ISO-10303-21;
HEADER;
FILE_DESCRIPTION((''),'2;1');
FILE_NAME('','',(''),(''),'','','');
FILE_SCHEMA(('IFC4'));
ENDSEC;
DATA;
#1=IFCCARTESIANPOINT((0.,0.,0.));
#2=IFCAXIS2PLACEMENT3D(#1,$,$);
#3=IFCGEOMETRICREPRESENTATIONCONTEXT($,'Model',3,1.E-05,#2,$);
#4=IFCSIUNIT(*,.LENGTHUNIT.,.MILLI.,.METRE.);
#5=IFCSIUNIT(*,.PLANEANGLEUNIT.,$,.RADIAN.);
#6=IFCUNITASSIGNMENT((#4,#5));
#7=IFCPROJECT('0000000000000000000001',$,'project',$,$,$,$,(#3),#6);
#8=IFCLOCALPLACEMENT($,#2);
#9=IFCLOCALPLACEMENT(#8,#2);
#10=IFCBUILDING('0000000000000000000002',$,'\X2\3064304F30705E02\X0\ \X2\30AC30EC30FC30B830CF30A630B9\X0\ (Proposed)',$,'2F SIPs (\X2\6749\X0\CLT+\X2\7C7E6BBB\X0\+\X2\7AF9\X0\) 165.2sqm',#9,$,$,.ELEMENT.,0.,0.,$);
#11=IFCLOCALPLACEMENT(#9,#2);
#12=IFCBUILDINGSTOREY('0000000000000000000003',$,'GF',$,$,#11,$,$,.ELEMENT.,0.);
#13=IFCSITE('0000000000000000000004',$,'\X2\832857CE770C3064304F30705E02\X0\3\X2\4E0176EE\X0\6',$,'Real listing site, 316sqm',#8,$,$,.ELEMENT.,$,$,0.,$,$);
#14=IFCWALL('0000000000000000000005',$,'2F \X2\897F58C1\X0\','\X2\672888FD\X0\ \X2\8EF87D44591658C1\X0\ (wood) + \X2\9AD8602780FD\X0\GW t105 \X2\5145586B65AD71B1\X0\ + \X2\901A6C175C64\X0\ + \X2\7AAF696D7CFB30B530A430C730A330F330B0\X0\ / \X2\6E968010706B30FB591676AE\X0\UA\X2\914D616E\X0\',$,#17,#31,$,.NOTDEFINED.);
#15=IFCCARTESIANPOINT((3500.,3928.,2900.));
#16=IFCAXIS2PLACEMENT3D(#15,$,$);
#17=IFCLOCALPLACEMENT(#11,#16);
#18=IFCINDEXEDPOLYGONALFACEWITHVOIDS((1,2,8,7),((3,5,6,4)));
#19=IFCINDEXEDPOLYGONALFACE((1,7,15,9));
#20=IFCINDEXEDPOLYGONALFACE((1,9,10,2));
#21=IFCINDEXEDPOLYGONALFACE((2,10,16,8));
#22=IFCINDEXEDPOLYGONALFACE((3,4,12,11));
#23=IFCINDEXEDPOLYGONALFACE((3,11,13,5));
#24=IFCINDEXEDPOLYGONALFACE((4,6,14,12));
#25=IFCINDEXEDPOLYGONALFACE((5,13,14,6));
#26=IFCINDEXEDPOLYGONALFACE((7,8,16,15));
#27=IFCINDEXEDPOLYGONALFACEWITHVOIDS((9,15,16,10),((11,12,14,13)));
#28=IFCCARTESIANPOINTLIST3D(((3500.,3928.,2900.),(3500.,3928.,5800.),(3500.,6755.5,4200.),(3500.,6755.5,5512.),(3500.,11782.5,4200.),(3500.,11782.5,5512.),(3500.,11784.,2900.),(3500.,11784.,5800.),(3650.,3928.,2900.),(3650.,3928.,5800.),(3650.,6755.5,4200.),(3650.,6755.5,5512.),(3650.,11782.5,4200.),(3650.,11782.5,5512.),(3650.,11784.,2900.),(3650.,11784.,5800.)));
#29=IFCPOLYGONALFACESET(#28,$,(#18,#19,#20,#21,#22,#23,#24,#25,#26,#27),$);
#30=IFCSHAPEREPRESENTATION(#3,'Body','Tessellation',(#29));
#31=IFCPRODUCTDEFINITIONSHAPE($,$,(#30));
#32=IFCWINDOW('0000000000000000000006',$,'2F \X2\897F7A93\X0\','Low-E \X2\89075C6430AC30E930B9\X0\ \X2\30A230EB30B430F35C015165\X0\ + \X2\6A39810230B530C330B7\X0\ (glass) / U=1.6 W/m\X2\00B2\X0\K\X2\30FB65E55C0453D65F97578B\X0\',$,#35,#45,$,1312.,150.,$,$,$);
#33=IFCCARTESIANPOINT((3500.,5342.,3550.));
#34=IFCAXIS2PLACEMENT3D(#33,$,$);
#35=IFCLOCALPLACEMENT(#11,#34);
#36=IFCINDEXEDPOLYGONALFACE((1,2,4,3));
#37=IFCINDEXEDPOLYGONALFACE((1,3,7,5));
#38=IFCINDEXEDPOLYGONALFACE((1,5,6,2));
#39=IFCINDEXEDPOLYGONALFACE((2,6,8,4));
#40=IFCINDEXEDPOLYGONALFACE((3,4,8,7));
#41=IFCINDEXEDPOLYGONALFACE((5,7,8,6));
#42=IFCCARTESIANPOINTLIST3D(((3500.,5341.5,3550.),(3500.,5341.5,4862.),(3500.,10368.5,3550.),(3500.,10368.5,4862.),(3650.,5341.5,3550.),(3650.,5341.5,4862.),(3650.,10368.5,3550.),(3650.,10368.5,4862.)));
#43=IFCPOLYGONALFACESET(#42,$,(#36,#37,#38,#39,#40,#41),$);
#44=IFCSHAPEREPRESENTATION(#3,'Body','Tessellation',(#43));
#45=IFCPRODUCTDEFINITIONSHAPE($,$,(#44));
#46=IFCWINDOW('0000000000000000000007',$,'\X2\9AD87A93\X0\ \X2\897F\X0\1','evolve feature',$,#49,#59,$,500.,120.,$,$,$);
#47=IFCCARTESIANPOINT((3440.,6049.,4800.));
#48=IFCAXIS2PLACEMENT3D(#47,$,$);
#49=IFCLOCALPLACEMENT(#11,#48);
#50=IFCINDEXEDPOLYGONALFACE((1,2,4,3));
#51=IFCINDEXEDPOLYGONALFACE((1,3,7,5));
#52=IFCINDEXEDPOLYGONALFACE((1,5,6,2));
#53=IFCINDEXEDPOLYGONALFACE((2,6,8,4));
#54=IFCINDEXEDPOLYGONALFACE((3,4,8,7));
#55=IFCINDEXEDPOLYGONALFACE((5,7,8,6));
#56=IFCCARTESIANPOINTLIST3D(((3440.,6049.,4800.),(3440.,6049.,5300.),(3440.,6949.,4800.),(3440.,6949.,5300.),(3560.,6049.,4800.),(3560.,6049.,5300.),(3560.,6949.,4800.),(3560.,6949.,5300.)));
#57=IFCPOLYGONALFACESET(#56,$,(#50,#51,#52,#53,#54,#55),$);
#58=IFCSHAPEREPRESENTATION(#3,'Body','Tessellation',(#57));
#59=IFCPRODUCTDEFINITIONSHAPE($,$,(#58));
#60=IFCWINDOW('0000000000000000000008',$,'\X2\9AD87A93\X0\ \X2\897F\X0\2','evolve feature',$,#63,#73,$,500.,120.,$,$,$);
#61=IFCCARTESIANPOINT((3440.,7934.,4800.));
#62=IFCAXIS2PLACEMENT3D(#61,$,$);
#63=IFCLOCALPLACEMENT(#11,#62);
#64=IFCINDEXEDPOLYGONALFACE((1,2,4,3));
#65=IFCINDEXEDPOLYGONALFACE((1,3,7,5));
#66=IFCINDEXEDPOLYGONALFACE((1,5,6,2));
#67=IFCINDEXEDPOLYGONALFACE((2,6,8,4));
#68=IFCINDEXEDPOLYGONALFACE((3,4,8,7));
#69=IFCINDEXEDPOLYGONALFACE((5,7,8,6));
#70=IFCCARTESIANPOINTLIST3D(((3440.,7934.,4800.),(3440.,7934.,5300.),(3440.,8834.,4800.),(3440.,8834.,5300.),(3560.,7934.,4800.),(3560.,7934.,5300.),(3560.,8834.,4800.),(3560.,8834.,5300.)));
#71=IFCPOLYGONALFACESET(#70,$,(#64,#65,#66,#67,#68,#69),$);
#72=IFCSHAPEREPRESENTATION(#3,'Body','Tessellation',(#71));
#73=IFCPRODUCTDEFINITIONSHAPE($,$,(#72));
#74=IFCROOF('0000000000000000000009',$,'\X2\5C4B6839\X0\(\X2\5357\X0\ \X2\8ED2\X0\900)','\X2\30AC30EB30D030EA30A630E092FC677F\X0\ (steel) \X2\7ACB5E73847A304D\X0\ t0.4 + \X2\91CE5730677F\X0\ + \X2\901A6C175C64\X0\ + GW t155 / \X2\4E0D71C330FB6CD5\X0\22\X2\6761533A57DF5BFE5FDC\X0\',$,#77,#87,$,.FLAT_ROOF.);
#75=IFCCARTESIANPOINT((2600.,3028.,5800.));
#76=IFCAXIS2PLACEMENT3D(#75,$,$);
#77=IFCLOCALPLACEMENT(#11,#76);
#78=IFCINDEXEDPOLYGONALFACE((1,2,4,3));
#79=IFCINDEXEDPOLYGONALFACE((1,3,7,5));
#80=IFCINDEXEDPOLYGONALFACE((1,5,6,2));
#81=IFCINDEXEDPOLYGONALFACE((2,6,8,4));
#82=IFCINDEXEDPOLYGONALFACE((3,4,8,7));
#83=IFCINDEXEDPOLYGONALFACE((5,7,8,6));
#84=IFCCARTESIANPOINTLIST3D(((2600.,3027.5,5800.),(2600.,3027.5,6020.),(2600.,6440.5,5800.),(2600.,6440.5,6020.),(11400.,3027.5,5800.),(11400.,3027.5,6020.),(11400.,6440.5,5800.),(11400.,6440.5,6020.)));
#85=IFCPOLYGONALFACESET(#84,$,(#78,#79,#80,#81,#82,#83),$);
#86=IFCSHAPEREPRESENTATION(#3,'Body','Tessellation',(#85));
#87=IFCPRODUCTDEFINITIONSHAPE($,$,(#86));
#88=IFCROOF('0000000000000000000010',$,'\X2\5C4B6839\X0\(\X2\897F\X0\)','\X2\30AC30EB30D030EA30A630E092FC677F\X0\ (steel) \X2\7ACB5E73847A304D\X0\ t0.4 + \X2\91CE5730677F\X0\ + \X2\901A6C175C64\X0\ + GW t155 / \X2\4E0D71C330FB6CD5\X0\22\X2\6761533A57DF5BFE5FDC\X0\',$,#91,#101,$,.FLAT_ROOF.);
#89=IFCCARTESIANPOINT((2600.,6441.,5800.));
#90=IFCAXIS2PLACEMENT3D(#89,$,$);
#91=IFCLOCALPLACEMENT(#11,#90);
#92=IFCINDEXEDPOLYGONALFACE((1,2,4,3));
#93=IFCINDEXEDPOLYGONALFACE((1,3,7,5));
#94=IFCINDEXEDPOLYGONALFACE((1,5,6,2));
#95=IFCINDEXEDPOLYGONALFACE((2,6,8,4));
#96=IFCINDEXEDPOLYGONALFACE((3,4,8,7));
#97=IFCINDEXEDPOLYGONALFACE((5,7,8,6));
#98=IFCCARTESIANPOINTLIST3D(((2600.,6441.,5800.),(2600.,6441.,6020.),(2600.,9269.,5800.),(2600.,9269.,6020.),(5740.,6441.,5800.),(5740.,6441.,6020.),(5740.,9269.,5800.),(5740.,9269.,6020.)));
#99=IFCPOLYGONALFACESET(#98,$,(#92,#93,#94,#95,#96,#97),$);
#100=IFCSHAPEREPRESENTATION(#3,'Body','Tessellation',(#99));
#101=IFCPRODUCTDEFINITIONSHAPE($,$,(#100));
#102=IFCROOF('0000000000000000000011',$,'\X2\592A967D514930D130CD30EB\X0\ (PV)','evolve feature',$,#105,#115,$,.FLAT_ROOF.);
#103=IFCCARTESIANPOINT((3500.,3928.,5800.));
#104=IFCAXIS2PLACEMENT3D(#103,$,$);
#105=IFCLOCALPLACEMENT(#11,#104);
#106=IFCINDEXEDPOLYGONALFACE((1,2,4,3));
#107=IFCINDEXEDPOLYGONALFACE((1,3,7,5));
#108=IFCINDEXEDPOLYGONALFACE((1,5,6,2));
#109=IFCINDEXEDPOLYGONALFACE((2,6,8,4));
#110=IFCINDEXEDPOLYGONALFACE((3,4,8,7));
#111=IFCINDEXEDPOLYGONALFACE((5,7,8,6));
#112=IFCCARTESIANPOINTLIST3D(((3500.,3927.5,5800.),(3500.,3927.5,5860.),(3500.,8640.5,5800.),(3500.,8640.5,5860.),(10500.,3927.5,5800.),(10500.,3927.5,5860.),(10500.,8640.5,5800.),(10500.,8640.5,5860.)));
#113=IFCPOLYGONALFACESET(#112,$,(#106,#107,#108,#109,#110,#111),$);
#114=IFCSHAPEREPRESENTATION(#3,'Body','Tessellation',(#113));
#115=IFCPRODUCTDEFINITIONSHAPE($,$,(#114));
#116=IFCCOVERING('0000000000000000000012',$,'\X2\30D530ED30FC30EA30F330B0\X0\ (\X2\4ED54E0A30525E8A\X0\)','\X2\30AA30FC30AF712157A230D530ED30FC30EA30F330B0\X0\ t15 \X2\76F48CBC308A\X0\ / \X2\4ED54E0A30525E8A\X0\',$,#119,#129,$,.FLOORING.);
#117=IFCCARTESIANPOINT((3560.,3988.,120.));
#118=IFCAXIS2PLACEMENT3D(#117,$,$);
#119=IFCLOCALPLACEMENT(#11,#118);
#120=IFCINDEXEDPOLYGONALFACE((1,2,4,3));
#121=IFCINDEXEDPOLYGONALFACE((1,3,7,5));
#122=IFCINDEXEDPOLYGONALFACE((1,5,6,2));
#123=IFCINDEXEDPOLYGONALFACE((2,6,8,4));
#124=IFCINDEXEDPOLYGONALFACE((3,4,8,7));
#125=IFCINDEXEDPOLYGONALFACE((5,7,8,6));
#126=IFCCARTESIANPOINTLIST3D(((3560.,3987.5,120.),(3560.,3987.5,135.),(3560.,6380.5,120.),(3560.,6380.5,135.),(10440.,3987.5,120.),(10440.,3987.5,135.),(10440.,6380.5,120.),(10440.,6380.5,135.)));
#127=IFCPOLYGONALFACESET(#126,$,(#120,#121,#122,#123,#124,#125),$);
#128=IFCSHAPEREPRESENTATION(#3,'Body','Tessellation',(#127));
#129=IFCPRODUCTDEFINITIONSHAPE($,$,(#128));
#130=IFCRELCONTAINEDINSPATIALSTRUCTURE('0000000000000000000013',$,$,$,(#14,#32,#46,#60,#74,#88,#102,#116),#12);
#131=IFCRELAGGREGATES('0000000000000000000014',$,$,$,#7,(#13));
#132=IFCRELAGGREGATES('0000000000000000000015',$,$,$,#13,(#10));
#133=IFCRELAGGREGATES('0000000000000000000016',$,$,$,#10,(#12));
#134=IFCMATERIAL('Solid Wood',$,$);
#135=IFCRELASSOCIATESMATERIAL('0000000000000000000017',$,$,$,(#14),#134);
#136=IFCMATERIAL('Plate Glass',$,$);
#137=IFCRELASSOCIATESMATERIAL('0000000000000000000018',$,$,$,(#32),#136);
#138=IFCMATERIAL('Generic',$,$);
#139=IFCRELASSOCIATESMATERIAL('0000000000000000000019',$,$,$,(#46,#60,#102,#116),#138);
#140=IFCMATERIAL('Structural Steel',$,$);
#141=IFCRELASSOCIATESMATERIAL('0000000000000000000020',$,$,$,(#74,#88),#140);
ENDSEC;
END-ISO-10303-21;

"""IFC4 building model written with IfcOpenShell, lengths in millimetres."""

from ifc_helpers import new_model, si_unit, frame, frame_2d, origin, place, context, project, spatial, rectangle, extrude, material, element, fill, save


model = new_model("IFC4")

# Units and contexts
model_context = context("Model", 3, precision=1e-05, world=origin())
ifc_project = project(units=[si_unit("LENGTHUNIT", "METRE", prefix="MILLI"), si_unit("PLANEANGLEUNIT", "RADIAN")], contexts=[model_context])

# Site, building, storey
site_placement = place(None, origin())
site = spatial("IfcSite", under=ifc_project, at=site_placement, Name="茨城県つくば市3丁目6", ObjectType="Real listing site, 316sqm", CompositionType="ELEMENT", RefElevation=0.0)
building_placement = place(site_placement, origin())
building = spatial("IfcBuilding", under=site, at=building_placement, Name="つくば市 ガレージハウス (Proposed)", ObjectType="2F SIPs (杉CLT+籾殻+竹) 165.2sqm", CompositionType="ELEMENT", ElevationOfRefHeight=0.0, ElevationOfTerrain=0.0)
storey_placement = place(building_placement, origin())
storey = spatial("IfcBuildingStorey", under=building, at=storey_placement, Name="GF", CompositionType="ELEMENT", Elevation=0.0)

# Shared definitions
ifc_material_1 = material(Name="Solid Wood")
ifc_material_2 = material(Name="Generic")

# Shared definitions
ifc_material_3 = material(Name="Plate Glass")

# Wall, openings, windows
wall_1_placement = place(storey_placement, frame((3500.0, 3928.0, 2900.0)))
wall_1 = element("IfcWall", 1, at=wall_1_placement, inside=storey, material=ifc_material_1, Name="2F 西壁", Description="木製 軸組外壁 (wood) + 高性能GW t105 充填断熱 + 通気層 + 窯業系サイディング / 準耐火・外皮UA配慮", PredefinedType="NOTDEFINED", context=model_context, shape_type="SweptSolid", body=[
    extrude(rectangle(XDim=150.0, YDim=7856.0, at=frame_2d((75.0, 3928.0))), frame((3500.0, 3928.0, 2900.0)), (0.0, 0.0, 1.0), 2900.0),
])
opening_1_placement = place(storey_placement, frame((3500.0, 5342.0, 3550.0)))
opening_1 = element("IfcOpeningElement", 2, at=opening_1_placement, cuts=wall_1, PredefinedType="NOTDEFINED", context=model_context, shape_type="SweptSolid", body=[
    extrude(rectangle(XDim=150.0, YDim=5027.0, at=frame_2d((75.0, 2513.0))), frame((3500.0, 5342.0, 3550.0)), (0.0, 0.0, 1.0), 1312.0),
])
opening_2_placement = place(storey_placement, frame((3440.0, 6049.0, 4800.0)))
opening_2 = element("IfcOpeningElement", 3, at=opening_2_placement, cuts=wall_1, PredefinedType="NOTDEFINED", context=model_context, shape_type="SweptSolid", body=[
    extrude(rectangle(XDim=120.0, YDim=900.0, at=frame_2d((60.0, 450.0))), frame((3440.0, 6049.0, 4800.0)), (0.0, 0.0, 1.0), 500.0),
])
opening_3_placement = place(storey_placement, frame((3440.0, 7934.0, 4800.0)))
opening_3 = element("IfcOpeningElement", 4, at=opening_3_placement, cuts=wall_1, PredefinedType="NOTDEFINED", context=model_context, shape_type="SweptSolid", body=[
    extrude(rectangle(XDim=120.0, YDim=900.0, at=frame_2d((60.0, 450.0))), frame((3440.0, 7934.0, 4800.0)), (0.0, 0.0, 1.0), 500.0),
])
window_1_placement = place(storey_placement, frame((3500.0, 5342.0, 3550.0)))
window_1 = element("IfcWindow", 5, at=window_1_placement, inside=storey, material=ifc_material_3, Name="2F 西窓", Description="Low-E 複層ガラス アルゴン封入 + 樹脂サッシ (glass) / U=1.6 W/m²K・日射取得型", OverallHeight=1312.0, OverallWidth=150.0, context=model_context, shape_type="SweptSolid", body=[
    extrude(rectangle(XDim=150.0, YDim=5027.0, at=frame_2d((75.0, 2513.0))), frame((3500.0, 5342.0, 3550.0)), (0.0, 0.0, 1.0), 1312.0),
])
fill(opening_1, window_1)
window_2_placement = place(storey_placement, frame((3440.0, 6049.0, 4800.0)))
window_2 = element("IfcWindow", 6, at=window_2_placement, inside=storey, material=ifc_material_2, Name="高窓 西1", Description="evolve feature", OverallHeight=500.0, OverallWidth=120.0, context=model_context, shape_type="SweptSolid", body=[
    extrude(rectangle(XDim=120.0, YDim=900.0, at=frame_2d((60.0, 450.0))), frame((3440.0, 6049.0, 4800.0)), (0.0, 0.0, 1.0), 500.0),
])
fill(opening_2, window_2)
window_3_placement = place(storey_placement, frame((3440.0, 7934.0, 4800.0)))
window_3 = element("IfcWindow", 7, at=window_3_placement, inside=storey, material=ifc_material_2, Name="高窓 西2", Description="evolve feature", OverallHeight=500.0, OverallWidth=120.0, context=model_context, shape_type="SweptSolid", body=[
    extrude(rectangle(XDim=120.0, YDim=900.0, at=frame_2d((60.0, 450.0))), frame((3440.0, 7934.0, 4800.0)), (0.0, 0.0, 1.0), 500.0),
])
fill(opening_3, window_3)

# Roofs
ifc_material_4 = material(Name="Structural Steel")
roof_1_placement = place(storey_placement, frame((2600.0, 3028.0, 5800.0)))
element("IfcRoof", 8, at=roof_1_placement, inside=storey, material=ifc_material_4, Name="屋根(南 軒900)", Description="ガルバリウム鋼板 (steel) 立平葺き t0.4 + 野地板 + 通気層 + GW t155 / 不燃・法22条区域対応", PredefinedType="FLAT_ROOF", context=model_context, shape_type="SweptSolid", body=[
    extrude(rectangle(XDim=8800.0, YDim=3413.0, at=frame_2d((4400.0, 1706.0))), frame((2600.0, 3028.0, 5800.0)), (0.0, 0.0, 1.0), 220.0),
])
roof_2_placement = place(storey_placement, frame((2600.0, 6441.0, 5800.0)))
element("IfcRoof", 9, at=roof_2_placement, inside=storey, material=ifc_material_4, Name="屋根(西)", Description="ガルバリウム鋼板 (steel) 立平葺き t0.4 + 野地板 + 通気層 + GW t155 / 不燃・法22条区域対応", PredefinedType="FLAT_ROOF", context=model_context, shape_type="SweptSolid", body=[
    extrude(rectangle(XDim=3140.0, YDim=2828.0, at=frame_2d((1570.0, 1414.0))), frame((2600.0, 6441.0, 5800.0)), (0.0, 0.0, 1.0), 220.0),
])
roof_3_placement = place(storey_placement, frame((3500.0, 3928.0, 5800.0)))
element("IfcRoof", 10, at=roof_3_placement, inside=storey, material=ifc_material_2, Name="太陽光パネル (PV)", Description="evolve feature", PredefinedType="FLAT_ROOF", context=model_context, shape_type="SweptSolid", body=[
    extrude(rectangle(XDim=7000.0, YDim=4713.0, at=frame_2d((3500.0, 2356.0))), frame((3500.0, 3928.0, 5800.0)), (0.0, 0.0, 1.0), 60.0),
])

# Covering
covering_placement = place(storey_placement, frame((3560.0, 3988.0, 120.0)))
element("IfcCovering", 11, at=covering_placement, inside=storey, material=ifc_material_2, Name="フローリング (仕上げ床)", Description="オーク無垢フローリング t15 直貼り / 仕上げ床", PredefinedType="FLOORING", context=model_context, shape_type="SweptSolid", body=[
    extrude(rectangle(XDim=6880.0, YDim=2393.0, at=frame_2d((3440.0, 1196.0))), frame((3560.0, 3988.0, 120.0)), (0.0, 0.0, 1.0), 15.0),
])

save(model, "model.ifc")
